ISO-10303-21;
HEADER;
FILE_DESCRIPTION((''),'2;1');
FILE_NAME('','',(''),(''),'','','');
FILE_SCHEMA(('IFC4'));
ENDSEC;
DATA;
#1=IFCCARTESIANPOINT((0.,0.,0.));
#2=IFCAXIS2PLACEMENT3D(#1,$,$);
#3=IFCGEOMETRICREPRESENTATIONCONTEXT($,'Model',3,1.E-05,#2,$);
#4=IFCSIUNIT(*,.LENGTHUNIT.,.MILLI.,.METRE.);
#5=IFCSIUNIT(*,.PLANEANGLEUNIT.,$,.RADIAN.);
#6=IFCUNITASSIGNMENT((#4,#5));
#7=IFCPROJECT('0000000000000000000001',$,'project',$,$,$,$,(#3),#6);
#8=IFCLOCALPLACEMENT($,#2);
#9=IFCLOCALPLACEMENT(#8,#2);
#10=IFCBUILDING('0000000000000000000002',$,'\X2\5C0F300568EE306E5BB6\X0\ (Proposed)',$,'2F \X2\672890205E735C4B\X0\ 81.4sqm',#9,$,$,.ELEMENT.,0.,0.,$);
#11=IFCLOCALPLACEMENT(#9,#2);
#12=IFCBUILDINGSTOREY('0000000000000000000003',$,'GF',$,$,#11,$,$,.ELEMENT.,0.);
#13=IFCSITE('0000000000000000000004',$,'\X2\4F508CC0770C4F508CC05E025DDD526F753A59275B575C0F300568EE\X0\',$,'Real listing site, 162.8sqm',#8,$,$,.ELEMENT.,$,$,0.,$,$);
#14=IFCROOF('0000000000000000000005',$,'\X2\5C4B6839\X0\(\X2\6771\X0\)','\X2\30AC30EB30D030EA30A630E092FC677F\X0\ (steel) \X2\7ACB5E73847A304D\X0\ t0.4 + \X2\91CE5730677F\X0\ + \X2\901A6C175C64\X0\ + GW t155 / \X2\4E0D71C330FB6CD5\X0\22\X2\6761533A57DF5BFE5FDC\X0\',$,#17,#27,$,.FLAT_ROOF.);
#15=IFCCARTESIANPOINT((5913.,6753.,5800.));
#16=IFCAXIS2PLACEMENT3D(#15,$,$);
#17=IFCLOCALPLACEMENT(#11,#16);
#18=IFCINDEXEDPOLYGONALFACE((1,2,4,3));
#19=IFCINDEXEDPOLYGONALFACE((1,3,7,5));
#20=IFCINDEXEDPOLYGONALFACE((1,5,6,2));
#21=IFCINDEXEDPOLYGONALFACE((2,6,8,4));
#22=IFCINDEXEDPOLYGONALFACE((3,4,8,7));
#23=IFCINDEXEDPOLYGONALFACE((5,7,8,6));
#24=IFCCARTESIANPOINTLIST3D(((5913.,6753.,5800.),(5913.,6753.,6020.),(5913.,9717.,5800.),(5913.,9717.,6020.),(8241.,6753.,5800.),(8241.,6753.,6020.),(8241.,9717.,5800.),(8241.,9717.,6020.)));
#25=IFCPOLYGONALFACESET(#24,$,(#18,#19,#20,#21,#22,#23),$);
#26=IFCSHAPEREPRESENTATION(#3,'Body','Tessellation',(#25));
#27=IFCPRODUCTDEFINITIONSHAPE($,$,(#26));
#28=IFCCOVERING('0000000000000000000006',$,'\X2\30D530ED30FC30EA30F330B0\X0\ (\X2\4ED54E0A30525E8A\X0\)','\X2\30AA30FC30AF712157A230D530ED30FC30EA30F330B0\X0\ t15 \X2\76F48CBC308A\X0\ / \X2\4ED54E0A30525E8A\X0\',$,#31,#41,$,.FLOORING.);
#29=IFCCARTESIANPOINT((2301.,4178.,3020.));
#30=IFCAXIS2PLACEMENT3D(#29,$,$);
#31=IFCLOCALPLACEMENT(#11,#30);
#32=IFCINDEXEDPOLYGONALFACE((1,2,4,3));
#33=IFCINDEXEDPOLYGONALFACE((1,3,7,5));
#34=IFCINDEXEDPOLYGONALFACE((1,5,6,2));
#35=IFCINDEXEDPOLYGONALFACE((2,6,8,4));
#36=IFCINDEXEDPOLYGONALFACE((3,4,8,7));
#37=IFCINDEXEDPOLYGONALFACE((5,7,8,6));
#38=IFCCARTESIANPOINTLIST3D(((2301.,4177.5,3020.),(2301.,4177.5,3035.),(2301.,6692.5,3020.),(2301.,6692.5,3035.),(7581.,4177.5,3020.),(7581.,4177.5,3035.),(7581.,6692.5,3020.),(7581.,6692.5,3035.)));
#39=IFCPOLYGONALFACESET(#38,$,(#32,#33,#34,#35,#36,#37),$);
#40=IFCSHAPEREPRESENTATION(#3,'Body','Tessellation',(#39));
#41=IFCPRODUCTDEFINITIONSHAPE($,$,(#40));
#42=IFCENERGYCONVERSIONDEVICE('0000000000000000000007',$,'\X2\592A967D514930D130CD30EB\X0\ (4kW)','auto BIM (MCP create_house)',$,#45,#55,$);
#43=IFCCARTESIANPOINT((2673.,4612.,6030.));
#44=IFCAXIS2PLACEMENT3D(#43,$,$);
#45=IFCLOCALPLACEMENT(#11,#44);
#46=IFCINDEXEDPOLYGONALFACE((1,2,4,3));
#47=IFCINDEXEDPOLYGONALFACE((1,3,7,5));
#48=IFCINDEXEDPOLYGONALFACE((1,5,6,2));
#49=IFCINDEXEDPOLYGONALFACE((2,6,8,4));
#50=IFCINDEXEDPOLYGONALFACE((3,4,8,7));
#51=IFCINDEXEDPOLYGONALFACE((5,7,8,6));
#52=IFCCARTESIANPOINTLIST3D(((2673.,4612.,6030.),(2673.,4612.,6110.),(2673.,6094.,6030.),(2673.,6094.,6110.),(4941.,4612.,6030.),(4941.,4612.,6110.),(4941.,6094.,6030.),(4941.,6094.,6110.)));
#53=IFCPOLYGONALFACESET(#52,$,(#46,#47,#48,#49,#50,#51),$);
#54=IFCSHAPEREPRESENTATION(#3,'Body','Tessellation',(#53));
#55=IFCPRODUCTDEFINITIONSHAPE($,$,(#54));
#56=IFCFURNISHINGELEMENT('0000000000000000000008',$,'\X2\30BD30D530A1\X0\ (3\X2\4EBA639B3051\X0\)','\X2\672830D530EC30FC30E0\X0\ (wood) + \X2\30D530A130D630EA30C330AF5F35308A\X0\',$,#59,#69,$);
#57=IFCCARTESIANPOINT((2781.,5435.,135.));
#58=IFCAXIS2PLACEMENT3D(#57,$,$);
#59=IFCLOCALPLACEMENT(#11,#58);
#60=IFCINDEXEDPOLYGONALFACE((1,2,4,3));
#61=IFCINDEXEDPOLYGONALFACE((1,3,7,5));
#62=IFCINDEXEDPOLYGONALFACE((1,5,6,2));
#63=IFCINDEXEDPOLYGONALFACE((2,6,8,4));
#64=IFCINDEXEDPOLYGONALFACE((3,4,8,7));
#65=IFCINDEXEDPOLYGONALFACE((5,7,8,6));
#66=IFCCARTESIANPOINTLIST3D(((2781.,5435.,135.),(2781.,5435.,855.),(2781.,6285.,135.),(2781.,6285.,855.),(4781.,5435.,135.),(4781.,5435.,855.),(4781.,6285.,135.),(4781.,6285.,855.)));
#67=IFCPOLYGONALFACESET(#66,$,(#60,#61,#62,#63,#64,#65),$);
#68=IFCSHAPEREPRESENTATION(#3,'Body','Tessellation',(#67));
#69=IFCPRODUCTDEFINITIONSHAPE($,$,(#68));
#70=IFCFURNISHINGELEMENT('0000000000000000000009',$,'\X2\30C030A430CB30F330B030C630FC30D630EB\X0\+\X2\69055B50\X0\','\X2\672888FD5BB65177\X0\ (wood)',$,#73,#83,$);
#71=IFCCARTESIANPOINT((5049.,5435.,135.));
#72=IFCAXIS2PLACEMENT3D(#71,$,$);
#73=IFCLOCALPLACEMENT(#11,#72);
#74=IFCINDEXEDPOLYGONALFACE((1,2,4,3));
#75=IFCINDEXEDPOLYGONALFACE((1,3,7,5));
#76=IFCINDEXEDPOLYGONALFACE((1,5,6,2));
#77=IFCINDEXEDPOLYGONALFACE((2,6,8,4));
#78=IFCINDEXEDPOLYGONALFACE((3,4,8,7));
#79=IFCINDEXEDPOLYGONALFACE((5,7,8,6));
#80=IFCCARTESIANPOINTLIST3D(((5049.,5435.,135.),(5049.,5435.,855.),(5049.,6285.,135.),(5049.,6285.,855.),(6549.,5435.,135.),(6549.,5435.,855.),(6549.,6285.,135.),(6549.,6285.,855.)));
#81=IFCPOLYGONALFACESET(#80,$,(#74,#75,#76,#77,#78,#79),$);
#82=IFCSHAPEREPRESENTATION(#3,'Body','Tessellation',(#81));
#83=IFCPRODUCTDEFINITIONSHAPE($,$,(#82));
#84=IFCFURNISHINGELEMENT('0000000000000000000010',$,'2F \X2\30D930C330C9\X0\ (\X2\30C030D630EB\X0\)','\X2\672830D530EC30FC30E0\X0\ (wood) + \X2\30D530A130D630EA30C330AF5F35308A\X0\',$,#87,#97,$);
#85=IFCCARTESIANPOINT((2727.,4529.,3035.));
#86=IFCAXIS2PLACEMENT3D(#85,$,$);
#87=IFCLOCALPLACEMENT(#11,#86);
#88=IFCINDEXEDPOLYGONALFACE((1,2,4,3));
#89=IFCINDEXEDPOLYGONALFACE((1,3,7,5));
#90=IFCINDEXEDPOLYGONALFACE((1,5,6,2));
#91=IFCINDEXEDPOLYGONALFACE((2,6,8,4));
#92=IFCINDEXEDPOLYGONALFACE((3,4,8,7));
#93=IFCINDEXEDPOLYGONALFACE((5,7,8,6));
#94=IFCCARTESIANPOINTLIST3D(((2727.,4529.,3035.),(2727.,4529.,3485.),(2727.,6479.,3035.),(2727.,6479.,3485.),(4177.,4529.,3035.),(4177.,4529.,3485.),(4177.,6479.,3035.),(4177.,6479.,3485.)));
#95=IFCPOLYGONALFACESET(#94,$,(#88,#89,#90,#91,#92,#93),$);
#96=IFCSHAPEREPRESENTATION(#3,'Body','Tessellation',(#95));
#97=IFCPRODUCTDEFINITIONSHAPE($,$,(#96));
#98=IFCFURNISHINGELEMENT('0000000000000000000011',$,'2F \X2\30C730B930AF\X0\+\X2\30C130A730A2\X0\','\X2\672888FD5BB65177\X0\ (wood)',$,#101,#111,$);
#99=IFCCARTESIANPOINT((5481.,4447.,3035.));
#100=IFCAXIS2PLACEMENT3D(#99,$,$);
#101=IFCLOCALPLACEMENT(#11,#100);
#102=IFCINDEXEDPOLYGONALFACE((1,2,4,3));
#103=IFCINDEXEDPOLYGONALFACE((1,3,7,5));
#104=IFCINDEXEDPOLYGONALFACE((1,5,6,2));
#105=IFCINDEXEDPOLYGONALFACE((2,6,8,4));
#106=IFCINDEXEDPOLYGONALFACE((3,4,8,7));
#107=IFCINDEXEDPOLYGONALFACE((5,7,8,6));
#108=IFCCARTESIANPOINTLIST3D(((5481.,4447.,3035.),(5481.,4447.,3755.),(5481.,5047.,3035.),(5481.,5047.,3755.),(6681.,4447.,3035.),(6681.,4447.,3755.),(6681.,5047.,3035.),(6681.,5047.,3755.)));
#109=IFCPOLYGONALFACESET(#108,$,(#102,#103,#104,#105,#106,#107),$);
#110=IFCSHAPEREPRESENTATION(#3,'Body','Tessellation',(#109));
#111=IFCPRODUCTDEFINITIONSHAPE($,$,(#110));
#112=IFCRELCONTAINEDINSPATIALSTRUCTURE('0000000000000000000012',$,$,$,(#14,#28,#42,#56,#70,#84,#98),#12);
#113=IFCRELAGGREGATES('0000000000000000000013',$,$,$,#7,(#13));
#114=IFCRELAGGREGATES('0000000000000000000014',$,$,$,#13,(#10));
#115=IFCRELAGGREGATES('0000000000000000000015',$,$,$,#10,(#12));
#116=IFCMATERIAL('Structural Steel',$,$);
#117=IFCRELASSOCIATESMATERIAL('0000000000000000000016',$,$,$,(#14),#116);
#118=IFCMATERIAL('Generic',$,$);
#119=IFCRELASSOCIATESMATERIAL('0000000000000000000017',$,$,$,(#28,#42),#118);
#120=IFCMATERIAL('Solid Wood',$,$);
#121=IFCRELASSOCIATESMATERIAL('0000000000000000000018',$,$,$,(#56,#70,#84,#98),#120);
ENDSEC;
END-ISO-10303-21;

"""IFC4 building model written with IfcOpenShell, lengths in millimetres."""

from ifc_helpers import new_model, si_unit, frame, frame_2d, origin, place, context, project, spatial, rectangle, extrude, material, element, save


model = new_model("IFC4")

# Units and contexts
model_context = context("Model", 3, precision=1e-05, world=origin())
ifc_project = project(units=[si_unit("LENGTHUNIT", "METRE", prefix="MILLI"), si_unit("PLANEANGLEUNIT", "RADIAN")], contexts=[model_context])

# Site, building, storey
site_placement = place(None, origin())
site = spatial("IfcSite", under=ifc_project, at=site_placement, Name="佐賀県佐賀市川副町大字小々森", ObjectType="Real listing site, 162.8sqm", CompositionType="ELEMENT", RefElevation=0.0)
building_placement = place(site_placement, origin())
building = spatial("IfcBuilding", under=site, at=building_placement, Name="小々森の家 (Proposed)", ObjectType="2F 木造平屋 81.4sqm", CompositionType="ELEMENT", ElevationOfRefHeight=0.0, ElevationOfTerrain=0.0)
storey_placement = place(building_placement, origin())
storey = spatial("IfcBuildingStorey", under=building, at=storey_placement, Name="GF", CompositionType="ELEMENT", Elevation=0.0)

# Shared definitions
ifc_material_1 = material(Name="Solid Wood")

# Roof
ifc_material_2 = material(Name="Structural Steel")
roof_1_placement = place(storey_placement, frame((5913.0, 6753.0, 5800.0)))
element("IfcRoof", 1, at=roof_1_placement, inside=storey, material=ifc_material_2, Name="屋根(東)", Description="ガルバリウム鋼板 (steel) 立平葺き t0.4 + 野地板 + 通気層 + GW t155 / 不燃・法22条区域対応", PredefinedType="FLAT_ROOF", context=model_context, shape_type="SweptSolid", body=[
    extrude(rectangle(XDim=2328.0, YDim=2964.0, at=frame_2d((1164.0, 1482.0))), frame((5913.0, 6753.0, 5800.0)), (0.0, 0.0, 1.0), 220.0),
])

# Covering
ifc_material_3 = material(Name="Generic")
covering_placement = place(storey_placement, frame((2301.0, 4178.0, 3020.0)))
element("IfcCovering", 2, at=covering_placement, inside=storey, material=ifc_material_3, Name="フローリング (仕上げ床)", Description="オーク無垢フローリング t15 直貼り / 仕上げ床", PredefinedType="FLOORING", context=model_context, shape_type="SweptSolid", body=[
    extrude(rectangle(XDim=5280.0, YDim=2515.0, at=frame_2d((2640.0, 1257.0))), frame((2301.0, 4178.0, 3020.0)), (0.0, 0.0, 1.0), 15.0),
])

# Energy conversion device
energy_conversion_device_placement = place(storey_placement, frame((2673.0, 4612.0, 6030.0)))
element("IfcEnergyConversionDevice", 3, at=energy_conversion_device_placement, inside=storey, material=ifc_material_3, Name="太陽光パネル (4kW)", Description="auto BIM (MCP create_house)", context=model_context, shape_type="SweptSolid", body=[
    extrude(rectangle(XDim=2268.0, YDim=1482.0, at=frame_2d((1134.0, 741.0))), frame((2673.0, 4612.0, 6030.0)), (0.0, 0.0, 1.0), 80.0),
])

# Furnishing elements
furnishing_1_placement = place(storey_placement, frame((2781.0, 5435.0, 135.0)))
element("IfcFurnishingElement", 4, at=furnishing_1_placement, inside=storey, material=ifc_material_1, Name="ソファ (3人掛け)", Description="木フレーム (wood) + ファブリック張り", context=model_context, shape_type="SweptSolid", body=[
    extrude(rectangle(XDim=2000.0, YDim=850.0, at=frame_2d((1000.0, 425.0))), frame((2781.0, 5435.0, 135.0)), (0.0, 0.0, 1.0), 720.0),
])
furnishing_2_placement = place(storey_placement, frame((5049.0, 5435.0, 135.0)))
element("IfcFurnishingElement", 5, at=furnishing_2_placement, inside=storey, material=ifc_material_1, Name="ダイニングテーブル+椅子", Description="木製家具 (wood)", context=model_context, shape_type="SweptSolid", body=[
    extrude(rectangle(XDim=1500.0, YDim=850.0, at=frame_2d((750.0, 425.0))), frame((5049.0, 5435.0, 135.0)), (0.0, 0.0, 1.0), 720.0),
])
furnishing_3_placement = place(storey_placement, frame((2727.0, 4529.0, 3035.0)))
element("IfcFurnishingElement", 6, at=furnishing_3_placement, inside=storey, material=ifc_material_1, Name="2F ベッド (ダブル)", Description="木フレーム (wood) + ファブリック張り", context=model_context, shape_type="SweptSolid", body=[
    extrude(rectangle(XDim=1450.0, YDim=1950.0, at=frame_2d((725.0, 975.0))), frame((2727.0, 4529.0, 3035.0)), (0.0, 0.0, 1.0), 450.0),
])
furnishing_4_placement = place(storey_placement, frame((5481.0, 4447.0, 3035.0)))
element("IfcFurnishingElement", 7, at=furnishing_4_placement, inside=storey, material=ifc_material_1, Name="2F デスク+チェア", Description="木製家具 (wood)", context=model_context, shape_type="SweptSolid", body=[
    extrude(rectangle(XDim=1200.0, YDim=600.0, at=frame_2d((600.0, 300.0))), frame((5481.0, 4447.0, 3035.0)), (0.0, 0.0, 1.0), 720.0),
])

save(model, "model.ifc")
